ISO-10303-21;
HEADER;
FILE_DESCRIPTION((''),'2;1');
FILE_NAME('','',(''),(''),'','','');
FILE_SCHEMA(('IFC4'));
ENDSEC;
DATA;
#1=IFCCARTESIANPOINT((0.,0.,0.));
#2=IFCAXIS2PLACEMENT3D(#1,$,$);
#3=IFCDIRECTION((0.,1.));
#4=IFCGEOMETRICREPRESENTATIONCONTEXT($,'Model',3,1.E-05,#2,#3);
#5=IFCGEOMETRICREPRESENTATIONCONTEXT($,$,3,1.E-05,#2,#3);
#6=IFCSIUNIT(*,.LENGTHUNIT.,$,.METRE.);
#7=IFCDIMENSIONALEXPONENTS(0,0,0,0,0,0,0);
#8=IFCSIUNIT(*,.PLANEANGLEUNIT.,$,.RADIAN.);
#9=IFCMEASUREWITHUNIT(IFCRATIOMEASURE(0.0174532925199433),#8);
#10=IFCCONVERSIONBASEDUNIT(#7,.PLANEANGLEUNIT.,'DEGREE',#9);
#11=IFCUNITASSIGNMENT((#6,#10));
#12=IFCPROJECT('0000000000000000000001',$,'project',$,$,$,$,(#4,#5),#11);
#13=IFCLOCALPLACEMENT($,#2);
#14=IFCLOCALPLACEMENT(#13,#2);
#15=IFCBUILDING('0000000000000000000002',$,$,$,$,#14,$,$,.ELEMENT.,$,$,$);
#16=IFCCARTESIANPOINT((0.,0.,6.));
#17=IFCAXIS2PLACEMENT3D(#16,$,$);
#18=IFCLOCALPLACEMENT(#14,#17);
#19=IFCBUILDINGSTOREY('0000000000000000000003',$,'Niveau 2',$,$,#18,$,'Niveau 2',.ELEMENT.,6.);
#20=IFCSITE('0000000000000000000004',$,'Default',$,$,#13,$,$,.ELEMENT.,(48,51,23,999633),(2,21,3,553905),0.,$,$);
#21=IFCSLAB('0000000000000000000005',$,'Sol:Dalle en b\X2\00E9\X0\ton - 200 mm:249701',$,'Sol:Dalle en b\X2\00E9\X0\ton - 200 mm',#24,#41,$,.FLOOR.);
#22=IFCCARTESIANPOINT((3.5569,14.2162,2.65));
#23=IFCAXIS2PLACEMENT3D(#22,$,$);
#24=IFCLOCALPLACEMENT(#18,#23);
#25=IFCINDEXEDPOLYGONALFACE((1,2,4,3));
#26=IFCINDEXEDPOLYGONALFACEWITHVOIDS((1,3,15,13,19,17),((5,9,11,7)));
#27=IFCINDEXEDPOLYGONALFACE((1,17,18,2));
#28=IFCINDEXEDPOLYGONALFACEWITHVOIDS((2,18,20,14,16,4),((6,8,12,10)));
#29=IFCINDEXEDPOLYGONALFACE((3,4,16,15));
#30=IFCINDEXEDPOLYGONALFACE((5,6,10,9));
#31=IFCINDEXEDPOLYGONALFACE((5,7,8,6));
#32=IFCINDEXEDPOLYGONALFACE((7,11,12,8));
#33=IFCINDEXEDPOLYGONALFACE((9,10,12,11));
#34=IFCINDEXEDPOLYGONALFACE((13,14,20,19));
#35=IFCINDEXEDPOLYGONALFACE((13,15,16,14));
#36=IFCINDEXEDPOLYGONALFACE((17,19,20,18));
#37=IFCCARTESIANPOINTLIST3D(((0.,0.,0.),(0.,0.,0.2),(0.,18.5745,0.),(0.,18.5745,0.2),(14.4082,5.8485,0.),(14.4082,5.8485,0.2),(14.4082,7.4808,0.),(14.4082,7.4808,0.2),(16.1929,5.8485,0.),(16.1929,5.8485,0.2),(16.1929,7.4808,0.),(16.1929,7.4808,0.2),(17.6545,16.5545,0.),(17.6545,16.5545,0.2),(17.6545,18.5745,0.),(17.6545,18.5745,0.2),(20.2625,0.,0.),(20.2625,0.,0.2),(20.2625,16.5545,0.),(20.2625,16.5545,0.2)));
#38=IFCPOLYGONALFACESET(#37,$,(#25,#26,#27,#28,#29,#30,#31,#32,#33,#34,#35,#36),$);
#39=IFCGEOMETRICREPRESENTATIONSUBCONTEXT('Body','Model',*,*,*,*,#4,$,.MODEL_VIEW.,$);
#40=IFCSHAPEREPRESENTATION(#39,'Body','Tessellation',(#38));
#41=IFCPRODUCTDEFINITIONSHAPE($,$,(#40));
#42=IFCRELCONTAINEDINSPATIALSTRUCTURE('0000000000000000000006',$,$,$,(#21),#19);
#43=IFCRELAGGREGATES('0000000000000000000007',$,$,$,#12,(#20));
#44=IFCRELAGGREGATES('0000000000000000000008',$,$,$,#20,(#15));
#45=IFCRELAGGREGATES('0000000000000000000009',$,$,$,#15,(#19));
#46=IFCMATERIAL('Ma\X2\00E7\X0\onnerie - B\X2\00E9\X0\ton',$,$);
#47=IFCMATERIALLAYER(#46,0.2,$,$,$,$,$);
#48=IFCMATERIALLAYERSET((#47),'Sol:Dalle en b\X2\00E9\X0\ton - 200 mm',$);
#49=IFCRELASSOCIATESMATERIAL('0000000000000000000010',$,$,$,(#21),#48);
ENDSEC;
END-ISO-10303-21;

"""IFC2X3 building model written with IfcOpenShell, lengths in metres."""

from ifc_helpers import new_model, entity, si_unit, converted_unit, direction, frame, origin, origin_2d_with_axis, place, context, subcontext, project, spatial, polyline, rectangle, outline, extrude, material, layer, layer_set, layer_usage, element, save


model = new_model("IFC2X3")

# Units and contexts
model_context = context("Model", 3, precision=1e-05, world=origin(), true_north=direction((0.0, 1.0)))
context_of_model = context(None, 3, precision=1e-05, world=origin(), true_north=direction((0.0, 1.0)))
body_context = subcontext(model_context, "Body", "Model", "MODEL_VIEW")
ifc_project = project(units=[si_unit("LENGTHUNIT", "METRE"), converted_unit("PLANEANGLEUNIT", "DEGREE", entity("IfcRatioMeasure", 0.0174532925199433), si_unit("PLANEANGLEUNIT", "RADIAN"), dimensions=[0, 0, 0, 0, 0, 0, 0])], contexts=[model_context, context_of_model])

# Site, building, storey
site_placement = place(None, origin())
site = spatial("IfcSite", under=ifc_project, at=site_placement, Name="Default", CompositionType="ELEMENT", RefLatitude=(48, 51, 23, 999633), RefLongitude=(2, 21, 3, 553905), RefElevation=0.0)
building_placement = place(site_placement, origin())
building = spatial("IfcBuilding", under=site, at=building_placement, CompositionType="ELEMENT")
storey_placement = place(building_placement, frame((0.0, 0.0, 6.0)))
storey = spatial("IfcBuildingStorey", under=building, at=storey_placement, Name="Niveau 2", LongName="Niveau 2", CompositionType="ELEMENT", Elevation=6.0)

# Shared definitions
ifc_material_1 = material(Name="Maçonnerie - Béton")
ifc_layer_1 = layer(ifc_material_1, 0.2)
ifc_layer_set_1 = layer_set([ifc_layer_1], Name="Sol:Dalle en béton - 200 mm")

# Slab, opening
ifc_layer_usage_1 = layer_usage(ifc_layer_set_1, "AXIS3", "POSITIVE", 0.0)
slab_1_placement = place(storey_placement, frame((3.5569, 14.2162, 2.65)))
slab_1 = element("IfcSlab", 1, at=slab_1_placement, inside=storey, material=ifc_layer_usage_1, Name="Sol:Dalle en béton - 200 mm:249701", ObjectType="Sol:Dalle en béton - 200 mm", PredefinedType="FLOOR", context=body_context, shape_type="SweptSolid", body=[
    extrude(outline(polyline([(-7.5232, 7.2672), (-10.1312, 7.2672), (-10.1312, -9.2872), (10.1312, -9.2872), (10.1312, 9.2872), (-7.5232, 9.2872), (-7.5232, 7.2672)])), frame((10.1312, 9.2872, 0.2), z_axis=(0.0, 0.0, -1.0), x_axis=(-1.0, 0.0, 0.0)), (0.0, 0.0, 1.0), 0.2),
])
opening_1_placement = place(slab_1_placement, frame((15.3005, 6.6646, 0.2)))
element("IfcOpeningElement", 2, at=opening_1_placement, cuts=slab_1, ObjectType="Opening", context=body_context, shape_type="SweptSolid", body=[
    extrude(rectangle(XDim=1.6324, YDim=1.7848, at=origin_2d_with_axis()), frame((0.0, 0.0, 0.0), z_axis=(0.0, 0.0, -1.0), x_axis=(0.0, -1.0, 0.0)), (0.0, 0.0, 1.0), 0.2),
])

save(model, "model.ifc")
